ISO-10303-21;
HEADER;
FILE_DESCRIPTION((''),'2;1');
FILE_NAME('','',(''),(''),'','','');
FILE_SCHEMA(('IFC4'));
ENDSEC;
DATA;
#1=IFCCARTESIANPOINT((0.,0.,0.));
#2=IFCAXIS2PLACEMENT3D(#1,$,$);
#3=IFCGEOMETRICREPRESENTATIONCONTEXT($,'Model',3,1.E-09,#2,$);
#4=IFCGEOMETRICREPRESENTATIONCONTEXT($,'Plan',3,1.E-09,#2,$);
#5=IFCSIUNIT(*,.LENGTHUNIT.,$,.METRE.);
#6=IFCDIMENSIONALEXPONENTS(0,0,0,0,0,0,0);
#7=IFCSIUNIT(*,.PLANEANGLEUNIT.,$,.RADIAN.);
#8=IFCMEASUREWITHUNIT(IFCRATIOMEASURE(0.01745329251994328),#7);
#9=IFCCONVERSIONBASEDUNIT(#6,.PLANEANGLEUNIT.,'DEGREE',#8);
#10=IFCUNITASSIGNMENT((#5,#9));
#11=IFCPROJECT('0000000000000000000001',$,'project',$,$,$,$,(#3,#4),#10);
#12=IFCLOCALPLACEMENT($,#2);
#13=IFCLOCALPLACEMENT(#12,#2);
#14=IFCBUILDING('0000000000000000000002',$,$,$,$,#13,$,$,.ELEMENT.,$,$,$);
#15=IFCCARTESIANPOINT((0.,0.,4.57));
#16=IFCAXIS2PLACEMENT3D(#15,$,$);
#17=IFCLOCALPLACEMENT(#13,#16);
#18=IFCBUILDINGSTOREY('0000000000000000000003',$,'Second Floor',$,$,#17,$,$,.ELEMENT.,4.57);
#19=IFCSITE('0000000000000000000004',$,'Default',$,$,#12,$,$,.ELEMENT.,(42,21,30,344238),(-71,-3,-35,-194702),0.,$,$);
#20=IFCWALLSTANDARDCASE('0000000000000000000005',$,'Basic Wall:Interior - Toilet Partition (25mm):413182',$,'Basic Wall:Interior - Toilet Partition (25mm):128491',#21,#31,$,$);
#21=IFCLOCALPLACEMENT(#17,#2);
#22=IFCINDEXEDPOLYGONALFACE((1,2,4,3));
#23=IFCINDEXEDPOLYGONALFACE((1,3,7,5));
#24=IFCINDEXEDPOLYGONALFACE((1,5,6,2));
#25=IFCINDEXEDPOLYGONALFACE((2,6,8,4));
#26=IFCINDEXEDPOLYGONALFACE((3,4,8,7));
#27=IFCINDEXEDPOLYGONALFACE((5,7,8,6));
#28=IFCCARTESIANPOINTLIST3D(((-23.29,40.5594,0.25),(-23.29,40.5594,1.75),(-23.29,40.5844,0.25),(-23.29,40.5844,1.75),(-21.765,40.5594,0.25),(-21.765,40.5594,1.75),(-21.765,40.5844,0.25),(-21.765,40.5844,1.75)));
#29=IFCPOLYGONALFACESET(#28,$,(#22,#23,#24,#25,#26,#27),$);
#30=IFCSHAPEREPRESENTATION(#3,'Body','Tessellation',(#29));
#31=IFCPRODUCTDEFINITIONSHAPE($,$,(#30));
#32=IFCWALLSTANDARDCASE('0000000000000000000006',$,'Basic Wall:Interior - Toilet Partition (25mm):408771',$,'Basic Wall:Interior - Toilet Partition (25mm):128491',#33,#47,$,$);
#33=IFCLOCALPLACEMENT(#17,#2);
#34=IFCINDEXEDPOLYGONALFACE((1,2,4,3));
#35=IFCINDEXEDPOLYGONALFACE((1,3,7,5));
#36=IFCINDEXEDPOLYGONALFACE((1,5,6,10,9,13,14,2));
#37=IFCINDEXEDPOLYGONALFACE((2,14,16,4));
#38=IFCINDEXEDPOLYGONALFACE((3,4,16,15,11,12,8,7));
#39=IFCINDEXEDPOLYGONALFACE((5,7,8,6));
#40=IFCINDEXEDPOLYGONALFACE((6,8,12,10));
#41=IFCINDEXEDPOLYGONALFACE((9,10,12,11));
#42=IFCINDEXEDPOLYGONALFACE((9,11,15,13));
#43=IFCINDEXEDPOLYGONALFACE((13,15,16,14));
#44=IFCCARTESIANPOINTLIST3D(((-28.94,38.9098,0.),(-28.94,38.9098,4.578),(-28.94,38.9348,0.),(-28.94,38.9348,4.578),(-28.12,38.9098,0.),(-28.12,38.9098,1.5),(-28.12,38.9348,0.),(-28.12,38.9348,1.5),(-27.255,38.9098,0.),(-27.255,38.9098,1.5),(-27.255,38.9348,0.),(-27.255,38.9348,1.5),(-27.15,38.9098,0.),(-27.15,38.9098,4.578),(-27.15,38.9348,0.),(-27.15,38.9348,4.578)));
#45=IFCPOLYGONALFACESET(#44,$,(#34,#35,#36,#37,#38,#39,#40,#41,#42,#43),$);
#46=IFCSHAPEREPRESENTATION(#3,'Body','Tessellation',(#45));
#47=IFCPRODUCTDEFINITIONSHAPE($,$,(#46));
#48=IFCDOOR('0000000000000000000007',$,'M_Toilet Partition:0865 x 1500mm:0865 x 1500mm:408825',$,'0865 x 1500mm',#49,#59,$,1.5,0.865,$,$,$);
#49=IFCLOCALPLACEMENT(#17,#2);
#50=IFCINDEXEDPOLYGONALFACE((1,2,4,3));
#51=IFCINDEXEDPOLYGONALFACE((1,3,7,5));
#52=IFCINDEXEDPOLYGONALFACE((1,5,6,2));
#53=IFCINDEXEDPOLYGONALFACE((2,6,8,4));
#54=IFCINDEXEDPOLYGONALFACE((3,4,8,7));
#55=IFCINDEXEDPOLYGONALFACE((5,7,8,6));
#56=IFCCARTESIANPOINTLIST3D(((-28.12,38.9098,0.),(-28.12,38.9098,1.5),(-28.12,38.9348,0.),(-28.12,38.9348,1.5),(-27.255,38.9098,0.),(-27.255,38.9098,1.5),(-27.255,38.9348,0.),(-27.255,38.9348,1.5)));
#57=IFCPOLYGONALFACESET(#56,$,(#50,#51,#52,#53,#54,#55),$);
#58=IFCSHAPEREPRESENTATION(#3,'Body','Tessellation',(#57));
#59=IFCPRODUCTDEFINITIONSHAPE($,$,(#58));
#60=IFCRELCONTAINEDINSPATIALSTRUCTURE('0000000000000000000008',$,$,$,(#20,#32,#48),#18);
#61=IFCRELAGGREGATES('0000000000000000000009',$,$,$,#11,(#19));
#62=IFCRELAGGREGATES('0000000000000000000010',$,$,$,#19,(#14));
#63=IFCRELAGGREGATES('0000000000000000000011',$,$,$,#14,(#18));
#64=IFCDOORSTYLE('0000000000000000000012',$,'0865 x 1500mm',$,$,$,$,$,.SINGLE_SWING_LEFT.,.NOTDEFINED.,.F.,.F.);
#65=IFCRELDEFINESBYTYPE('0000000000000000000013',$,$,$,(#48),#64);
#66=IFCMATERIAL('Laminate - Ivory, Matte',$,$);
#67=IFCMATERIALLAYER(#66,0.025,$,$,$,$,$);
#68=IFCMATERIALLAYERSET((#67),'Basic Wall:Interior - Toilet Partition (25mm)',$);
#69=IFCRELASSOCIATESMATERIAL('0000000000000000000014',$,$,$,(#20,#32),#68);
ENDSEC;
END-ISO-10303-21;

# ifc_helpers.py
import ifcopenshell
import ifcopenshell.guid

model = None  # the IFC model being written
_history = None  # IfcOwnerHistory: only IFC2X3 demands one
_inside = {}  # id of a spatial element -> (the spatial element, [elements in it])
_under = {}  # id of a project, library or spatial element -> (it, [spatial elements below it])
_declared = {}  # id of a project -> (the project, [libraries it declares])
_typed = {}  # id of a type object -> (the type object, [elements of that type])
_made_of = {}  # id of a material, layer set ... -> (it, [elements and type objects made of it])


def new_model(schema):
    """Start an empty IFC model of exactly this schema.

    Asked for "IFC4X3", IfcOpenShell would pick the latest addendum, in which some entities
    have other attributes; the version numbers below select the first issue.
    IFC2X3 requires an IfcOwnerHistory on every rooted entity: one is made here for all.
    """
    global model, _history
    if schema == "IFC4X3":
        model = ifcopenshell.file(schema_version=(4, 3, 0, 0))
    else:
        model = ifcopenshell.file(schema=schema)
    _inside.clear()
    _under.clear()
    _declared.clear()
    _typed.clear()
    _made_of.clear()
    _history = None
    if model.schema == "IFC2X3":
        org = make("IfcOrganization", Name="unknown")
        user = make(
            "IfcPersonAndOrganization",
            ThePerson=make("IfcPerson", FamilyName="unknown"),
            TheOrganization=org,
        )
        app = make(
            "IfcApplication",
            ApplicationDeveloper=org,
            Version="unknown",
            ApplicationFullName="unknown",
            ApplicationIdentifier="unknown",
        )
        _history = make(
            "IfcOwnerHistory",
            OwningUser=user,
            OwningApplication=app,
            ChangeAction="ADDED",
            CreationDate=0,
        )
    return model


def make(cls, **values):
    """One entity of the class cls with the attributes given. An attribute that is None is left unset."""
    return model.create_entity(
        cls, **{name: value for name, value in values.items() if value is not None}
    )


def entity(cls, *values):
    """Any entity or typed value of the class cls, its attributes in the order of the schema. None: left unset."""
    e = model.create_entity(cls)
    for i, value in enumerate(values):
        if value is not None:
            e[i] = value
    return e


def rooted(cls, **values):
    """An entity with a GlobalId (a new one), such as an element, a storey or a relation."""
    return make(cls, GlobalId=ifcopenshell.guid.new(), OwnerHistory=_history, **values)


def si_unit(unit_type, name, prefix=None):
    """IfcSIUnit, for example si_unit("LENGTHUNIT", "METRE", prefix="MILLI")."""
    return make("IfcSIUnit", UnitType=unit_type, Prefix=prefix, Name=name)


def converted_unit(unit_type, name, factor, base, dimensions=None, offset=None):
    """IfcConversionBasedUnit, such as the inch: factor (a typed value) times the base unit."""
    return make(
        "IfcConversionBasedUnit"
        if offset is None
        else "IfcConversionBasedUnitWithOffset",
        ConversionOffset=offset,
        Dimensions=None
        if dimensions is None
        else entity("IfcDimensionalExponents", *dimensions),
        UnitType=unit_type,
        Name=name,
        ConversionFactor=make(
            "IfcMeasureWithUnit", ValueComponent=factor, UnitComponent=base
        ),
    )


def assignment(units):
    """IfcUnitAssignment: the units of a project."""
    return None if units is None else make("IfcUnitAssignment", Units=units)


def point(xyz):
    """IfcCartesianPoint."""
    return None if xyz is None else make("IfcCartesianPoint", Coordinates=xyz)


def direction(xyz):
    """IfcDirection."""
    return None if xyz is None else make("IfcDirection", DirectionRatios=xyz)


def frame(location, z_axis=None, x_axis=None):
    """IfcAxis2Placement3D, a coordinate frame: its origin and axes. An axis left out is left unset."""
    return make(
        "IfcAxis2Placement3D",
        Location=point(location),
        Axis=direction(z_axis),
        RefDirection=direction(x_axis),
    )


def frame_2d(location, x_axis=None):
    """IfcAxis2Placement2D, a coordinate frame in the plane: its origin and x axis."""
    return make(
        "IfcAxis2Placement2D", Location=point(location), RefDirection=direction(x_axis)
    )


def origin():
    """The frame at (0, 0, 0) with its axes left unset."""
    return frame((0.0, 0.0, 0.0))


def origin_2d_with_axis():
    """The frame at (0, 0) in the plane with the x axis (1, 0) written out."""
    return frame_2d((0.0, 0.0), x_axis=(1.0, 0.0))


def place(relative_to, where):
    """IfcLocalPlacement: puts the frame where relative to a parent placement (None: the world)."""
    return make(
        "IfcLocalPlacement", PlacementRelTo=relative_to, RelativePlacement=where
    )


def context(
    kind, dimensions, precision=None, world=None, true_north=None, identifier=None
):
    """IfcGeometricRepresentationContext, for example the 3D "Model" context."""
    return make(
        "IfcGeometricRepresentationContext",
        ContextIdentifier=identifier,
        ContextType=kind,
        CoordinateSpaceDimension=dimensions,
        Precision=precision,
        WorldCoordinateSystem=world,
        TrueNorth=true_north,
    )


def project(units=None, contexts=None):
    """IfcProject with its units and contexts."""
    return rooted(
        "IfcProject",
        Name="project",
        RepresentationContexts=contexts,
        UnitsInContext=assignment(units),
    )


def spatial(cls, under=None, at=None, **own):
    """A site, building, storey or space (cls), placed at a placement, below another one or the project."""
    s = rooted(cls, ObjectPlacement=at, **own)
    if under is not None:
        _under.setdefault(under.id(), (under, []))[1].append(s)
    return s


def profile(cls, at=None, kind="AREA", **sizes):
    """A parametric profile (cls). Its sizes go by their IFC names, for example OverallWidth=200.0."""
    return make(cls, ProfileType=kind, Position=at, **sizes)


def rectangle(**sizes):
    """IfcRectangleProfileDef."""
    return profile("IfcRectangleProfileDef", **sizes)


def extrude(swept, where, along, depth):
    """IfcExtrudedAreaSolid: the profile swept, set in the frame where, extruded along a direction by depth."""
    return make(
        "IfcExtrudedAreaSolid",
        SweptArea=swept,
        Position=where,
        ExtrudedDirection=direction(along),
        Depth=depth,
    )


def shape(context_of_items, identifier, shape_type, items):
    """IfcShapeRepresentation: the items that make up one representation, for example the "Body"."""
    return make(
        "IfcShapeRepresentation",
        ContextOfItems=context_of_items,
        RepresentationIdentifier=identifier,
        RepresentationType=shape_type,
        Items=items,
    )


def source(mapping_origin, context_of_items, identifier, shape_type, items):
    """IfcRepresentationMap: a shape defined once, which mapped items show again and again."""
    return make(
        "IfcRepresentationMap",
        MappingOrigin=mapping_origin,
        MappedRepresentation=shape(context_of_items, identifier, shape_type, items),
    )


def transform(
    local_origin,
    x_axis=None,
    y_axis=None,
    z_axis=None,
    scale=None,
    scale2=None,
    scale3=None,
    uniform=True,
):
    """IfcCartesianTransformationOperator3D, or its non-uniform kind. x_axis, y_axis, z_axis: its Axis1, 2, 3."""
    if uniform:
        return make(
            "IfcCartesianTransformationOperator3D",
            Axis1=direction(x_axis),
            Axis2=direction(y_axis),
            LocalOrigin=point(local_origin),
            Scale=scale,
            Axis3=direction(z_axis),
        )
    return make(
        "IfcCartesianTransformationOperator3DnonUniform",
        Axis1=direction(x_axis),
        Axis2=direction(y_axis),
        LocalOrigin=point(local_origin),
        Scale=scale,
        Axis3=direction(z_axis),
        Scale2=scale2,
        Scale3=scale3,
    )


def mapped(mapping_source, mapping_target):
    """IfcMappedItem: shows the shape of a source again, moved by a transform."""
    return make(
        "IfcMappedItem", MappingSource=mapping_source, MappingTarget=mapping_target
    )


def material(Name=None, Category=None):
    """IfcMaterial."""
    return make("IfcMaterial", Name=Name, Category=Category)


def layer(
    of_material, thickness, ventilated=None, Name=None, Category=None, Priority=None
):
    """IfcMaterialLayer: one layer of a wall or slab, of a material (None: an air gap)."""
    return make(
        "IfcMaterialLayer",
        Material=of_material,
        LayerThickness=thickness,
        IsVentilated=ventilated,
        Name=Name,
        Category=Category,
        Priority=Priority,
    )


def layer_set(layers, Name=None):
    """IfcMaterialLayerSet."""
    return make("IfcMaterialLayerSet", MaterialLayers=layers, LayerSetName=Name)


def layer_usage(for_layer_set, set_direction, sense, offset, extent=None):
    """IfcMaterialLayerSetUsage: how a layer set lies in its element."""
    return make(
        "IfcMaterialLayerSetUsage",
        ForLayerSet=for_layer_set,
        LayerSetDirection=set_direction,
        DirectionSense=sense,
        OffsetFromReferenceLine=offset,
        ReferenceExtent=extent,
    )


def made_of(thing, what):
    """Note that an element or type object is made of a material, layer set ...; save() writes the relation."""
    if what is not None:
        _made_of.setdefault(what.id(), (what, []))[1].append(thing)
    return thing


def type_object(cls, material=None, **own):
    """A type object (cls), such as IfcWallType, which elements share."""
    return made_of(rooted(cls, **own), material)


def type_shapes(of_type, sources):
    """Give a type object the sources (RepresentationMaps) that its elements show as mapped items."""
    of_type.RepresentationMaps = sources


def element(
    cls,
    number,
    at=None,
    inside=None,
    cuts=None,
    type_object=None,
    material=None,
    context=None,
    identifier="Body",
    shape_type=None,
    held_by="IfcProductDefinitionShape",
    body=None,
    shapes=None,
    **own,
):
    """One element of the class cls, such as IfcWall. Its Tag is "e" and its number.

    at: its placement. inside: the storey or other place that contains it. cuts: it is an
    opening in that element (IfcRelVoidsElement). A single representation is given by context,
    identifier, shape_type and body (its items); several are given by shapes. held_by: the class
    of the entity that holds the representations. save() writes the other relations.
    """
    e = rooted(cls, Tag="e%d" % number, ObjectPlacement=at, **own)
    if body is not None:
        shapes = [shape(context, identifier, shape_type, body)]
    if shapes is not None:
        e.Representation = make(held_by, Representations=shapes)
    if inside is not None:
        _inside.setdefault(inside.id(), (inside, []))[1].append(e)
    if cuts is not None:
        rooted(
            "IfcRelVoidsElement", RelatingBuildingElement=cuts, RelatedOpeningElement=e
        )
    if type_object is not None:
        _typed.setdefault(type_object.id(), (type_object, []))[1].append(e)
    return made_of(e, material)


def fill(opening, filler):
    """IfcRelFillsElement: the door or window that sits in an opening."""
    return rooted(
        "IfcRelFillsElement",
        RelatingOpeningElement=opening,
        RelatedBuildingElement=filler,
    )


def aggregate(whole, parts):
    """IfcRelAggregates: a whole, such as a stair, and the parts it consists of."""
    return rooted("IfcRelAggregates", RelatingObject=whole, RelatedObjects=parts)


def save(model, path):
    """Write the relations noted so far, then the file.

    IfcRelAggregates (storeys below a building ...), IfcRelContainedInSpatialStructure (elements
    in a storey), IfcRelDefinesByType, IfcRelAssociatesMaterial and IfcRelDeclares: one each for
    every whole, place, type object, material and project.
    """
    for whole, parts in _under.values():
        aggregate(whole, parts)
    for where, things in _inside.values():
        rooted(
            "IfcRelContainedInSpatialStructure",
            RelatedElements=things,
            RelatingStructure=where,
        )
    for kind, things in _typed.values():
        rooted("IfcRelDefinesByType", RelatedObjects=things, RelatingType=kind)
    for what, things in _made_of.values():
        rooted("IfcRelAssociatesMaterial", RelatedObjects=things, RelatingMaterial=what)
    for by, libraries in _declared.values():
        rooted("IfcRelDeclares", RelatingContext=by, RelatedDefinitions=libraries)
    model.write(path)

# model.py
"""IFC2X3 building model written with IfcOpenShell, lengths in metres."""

from ifc_helpers import new_model, entity, si_unit, converted_unit, frame, frame_2d, origin, origin_2d_with_axis, place, context, project, spatial, rectangle, extrude, source, transform, mapped, material, layer, layer_set, layer_usage, type_object, type_shapes, element, fill, save


model = new_model("IFC2X3")

# Units and contexts
model_context = context("Model", 3, precision=1e-09, world=origin())
plan_context = context("Plan", 3, precision=1e-09, world=origin())
ifc_project = project(units=[si_unit("LENGTHUNIT", "METRE"), converted_unit("PLANEANGLEUNIT", "DEGREE", entity("IfcRatioMeasure", 0.01745329251994328), si_unit("PLANEANGLEUNIT", "RADIAN"), dimensions=[0, 0, 0, 0, 0, 0, 0])], contexts=[model_context, plan_context])

# Site, building, storey
site_placement = place(None, origin())
site = spatial("IfcSite", under=ifc_project, at=site_placement, Name="Default", CompositionType="ELEMENT", RefLatitude=(42, 21, 30, 344238), RefLongitude=(-71, -3, -35, -194702), RefElevation=0.0)
building_placement = place(site_placement, origin())
building = spatial("IfcBuilding", under=site, at=building_placement, CompositionType="ELEMENT")
storey_placement = place(building_placement, frame((0.0, 0.0, 4.57)))
storey = spatial("IfcBuildingStorey", under=building, at=storey_placement, Name="Second Floor", CompositionType="ELEMENT", Elevation=4.57)

# Shared definitions
ifc_material_1 = material(Name="Laminate - Ivory, Matte")
ifc_layer_1 = layer(ifc_material_1, 0.025)
ifc_layer_set_1 = layer_set([ifc_layer_1], Name="Basic Wall:Interior - Toilet Partition (25mm)")
ifc_layer_usage_1 = layer_usage(ifc_layer_set_1, "AXIS2", "NEGATIVE", 0.0125)
door_style_1 = type_object("IfcDoorStyle", Name="0865 x 1500mm", ConstructionType="NOTDEFINED", OperationType="SINGLE_SWING_LEFT", ParameterTakesPrecedence=False, Sizeable=False)
shared_shape_1 = source(origin(), model_context, "Body", "SweptSolid", [
    extrude(rectangle(XDim=0.865, YDim=0.025, at=origin_2d_with_axis()), frame((0.4325, 0.0125, 0.0)), (0.0, 0.0, 1.0), 1.5),
])
type_shapes(door_style_1, [shared_shape_1])

# Wall
wall_1_placement = place(storey_placement, frame((-23.29, 40.5719, 0.25)))
element("IfcWallStandardCase", 1, at=wall_1_placement, inside=storey, material=ifc_layer_usage_1, Name="Basic Wall:Interior - Toilet Partition (25mm):413182", ObjectType="Basic Wall:Interior - Toilet Partition (25mm):128491", context=model_context, shape_type="SweptSolid", body=[
    extrude(rectangle(XDim=1.525, YDim=0.025, at=frame_2d((0.7625, 0.0), x_axis=(-1.0, 0.0))), origin(), (0.0, 0.0, 1.0), 1.5),
])

# Wall, opening, door
wall_2_placement = place(storey_placement, frame((-28.94, 38.9223, 0.0)))
wall_2 = element("IfcWallStandardCase", 2, at=wall_2_placement, inside=storey, material=ifc_layer_usage_1, Name="Basic Wall:Interior - Toilet Partition (25mm):408771", ObjectType="Basic Wall:Interior - Toilet Partition (25mm):128491", context=model_context, shape_type="SweptSolid", body=[
    extrude(rectangle(XDim=1.79, YDim=0.025, at=frame_2d((0.895, 0.0), x_axis=(-1.0, 0.0))), origin(), (0.0, 0.0, 1.0), 4.578),
])
opening_1_placement = place(wall_2_placement, frame((1.685, 0.0125, 0.0)))
opening_1 = element("IfcOpeningElement", 3, at=opening_1_placement, cuts=wall_2, ObjectType="Opening", context=model_context, shape_type="SweptSolid", body=[
    extrude(rectangle(XDim=0.865, YDim=1.5, at=frame_2d((0.75, 0.4325), x_axis=(0.0, -1.0))), frame((0.0, 0.0, 0.0), z_axis=(0.0, -1.0, 0.0), x_axis=(0.0, 0.0, 1.0)), (0.0, 0.0, 1.0), 0.025),
])
door_1_placement = place(opening_1_placement, frame((0.0, 0.0, 0.0), z_axis=(0.0, 0.0, 1.0), x_axis=(-1.0, 0.0, 0.0)))
door_1 = element("IfcDoor", 4, at=door_1_placement, inside=storey, type_object=door_style_1, Name="M_Toilet Partition:0865 x 1500mm:0865 x 1500mm:408825", ObjectType="0865 x 1500mm", OverallHeight=1.5, OverallWidth=0.865, context=model_context, shape_type="MappedRepresentation", body=[
    mapped(shared_shape_1, transform((0.0, 0.0, 0.0), scale=1.0)),
])
fill(opening_1, door_1)

save(model, "model.ifc")
